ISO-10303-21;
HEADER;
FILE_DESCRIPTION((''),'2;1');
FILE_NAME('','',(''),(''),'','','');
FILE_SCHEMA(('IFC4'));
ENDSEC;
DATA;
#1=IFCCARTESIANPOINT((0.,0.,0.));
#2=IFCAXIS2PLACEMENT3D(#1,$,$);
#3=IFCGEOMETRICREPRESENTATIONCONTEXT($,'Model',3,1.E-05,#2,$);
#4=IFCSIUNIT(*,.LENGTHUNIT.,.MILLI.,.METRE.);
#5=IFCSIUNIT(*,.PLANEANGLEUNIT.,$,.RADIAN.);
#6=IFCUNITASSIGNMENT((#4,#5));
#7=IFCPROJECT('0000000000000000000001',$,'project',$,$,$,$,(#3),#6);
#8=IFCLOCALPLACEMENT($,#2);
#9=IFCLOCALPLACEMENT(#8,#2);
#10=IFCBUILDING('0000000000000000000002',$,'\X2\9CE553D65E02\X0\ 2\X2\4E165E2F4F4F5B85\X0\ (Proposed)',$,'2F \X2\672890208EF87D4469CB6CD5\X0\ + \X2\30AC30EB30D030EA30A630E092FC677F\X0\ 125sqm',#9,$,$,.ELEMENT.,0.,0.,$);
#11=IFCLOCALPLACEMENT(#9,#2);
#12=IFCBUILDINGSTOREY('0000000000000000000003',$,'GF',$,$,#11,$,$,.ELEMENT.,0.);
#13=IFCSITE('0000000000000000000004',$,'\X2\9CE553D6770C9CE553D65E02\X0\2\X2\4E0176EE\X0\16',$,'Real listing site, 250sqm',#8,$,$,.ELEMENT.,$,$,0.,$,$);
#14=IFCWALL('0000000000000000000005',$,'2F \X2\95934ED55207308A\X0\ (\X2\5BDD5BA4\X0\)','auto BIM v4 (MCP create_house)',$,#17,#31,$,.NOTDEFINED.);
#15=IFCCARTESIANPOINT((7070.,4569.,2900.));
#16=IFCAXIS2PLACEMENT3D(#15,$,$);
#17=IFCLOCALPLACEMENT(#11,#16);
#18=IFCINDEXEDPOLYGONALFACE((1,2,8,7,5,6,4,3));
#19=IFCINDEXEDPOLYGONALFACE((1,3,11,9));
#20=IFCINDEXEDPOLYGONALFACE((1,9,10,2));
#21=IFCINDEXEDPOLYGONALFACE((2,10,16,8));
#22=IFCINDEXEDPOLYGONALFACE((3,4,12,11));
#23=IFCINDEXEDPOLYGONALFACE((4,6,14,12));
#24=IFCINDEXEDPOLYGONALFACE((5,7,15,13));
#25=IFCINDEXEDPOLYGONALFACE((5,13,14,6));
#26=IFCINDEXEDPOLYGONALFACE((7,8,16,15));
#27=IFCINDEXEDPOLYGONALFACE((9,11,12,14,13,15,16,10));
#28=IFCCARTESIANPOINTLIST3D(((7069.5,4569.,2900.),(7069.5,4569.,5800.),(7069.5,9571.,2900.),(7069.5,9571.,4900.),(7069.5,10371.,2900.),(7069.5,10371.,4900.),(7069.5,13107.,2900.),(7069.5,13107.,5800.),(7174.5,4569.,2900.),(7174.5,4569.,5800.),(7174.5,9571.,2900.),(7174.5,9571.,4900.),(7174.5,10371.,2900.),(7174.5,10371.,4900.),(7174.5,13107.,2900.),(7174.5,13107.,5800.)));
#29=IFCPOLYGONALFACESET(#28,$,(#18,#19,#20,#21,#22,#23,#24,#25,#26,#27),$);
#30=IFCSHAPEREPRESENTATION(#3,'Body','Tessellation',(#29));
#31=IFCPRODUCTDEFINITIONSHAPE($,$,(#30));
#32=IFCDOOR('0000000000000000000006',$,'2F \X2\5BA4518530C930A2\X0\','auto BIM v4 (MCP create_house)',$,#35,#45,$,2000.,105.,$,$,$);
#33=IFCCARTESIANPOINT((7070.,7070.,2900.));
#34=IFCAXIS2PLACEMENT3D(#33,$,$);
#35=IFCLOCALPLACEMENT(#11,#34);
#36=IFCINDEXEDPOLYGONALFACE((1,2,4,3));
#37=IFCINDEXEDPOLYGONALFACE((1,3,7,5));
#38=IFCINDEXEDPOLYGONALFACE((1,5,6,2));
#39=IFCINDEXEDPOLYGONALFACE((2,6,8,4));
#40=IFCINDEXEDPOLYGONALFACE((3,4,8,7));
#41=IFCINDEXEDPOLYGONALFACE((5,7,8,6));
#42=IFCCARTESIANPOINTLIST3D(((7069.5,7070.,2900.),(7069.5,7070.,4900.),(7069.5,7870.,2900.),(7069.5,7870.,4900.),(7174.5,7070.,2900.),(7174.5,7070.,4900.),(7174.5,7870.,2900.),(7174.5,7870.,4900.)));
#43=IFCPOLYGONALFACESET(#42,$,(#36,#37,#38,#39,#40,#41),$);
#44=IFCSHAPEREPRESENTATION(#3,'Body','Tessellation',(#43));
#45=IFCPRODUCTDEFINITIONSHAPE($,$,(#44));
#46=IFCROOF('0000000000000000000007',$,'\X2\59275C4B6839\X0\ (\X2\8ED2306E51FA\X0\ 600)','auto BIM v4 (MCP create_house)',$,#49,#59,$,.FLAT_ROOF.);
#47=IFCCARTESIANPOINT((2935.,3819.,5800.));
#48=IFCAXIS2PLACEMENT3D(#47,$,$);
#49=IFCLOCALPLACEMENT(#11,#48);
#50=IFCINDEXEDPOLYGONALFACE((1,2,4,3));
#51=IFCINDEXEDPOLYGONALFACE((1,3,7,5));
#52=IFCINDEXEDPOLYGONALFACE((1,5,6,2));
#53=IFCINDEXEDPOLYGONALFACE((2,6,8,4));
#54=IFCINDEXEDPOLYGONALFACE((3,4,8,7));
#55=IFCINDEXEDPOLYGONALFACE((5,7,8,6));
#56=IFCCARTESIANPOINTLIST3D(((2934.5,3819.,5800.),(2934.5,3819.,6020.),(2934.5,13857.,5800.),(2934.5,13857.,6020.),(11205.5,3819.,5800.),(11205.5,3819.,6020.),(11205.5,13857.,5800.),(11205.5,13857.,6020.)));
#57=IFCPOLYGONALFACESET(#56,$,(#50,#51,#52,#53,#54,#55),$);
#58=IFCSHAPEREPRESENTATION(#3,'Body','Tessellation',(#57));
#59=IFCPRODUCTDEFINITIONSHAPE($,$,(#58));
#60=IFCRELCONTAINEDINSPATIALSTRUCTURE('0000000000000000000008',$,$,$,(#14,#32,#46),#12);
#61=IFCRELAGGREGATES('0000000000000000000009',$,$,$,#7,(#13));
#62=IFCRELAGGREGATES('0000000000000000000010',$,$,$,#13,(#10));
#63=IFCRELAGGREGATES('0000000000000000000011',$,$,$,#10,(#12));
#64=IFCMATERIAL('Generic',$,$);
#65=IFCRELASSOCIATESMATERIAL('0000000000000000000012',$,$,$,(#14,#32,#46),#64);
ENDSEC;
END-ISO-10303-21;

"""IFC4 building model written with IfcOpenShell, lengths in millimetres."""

from ifc_helpers import new_model, si_unit, frame, frame_2d, origin, place, context, project, spatial, rectangle, extrude, material, element, fill, save


model = new_model("IFC4")

# Units and contexts
model_context = context("Model", 3, precision=1e-05, world=origin())
ifc_project = project(units=[si_unit("LENGTHUNIT", "METRE", prefix="MILLI"), si_unit("PLANEANGLEUNIT", "RADIAN")], contexts=[model_context])

# Site, building, storey
site_placement = place(None, origin())
site = spatial("IfcSite", under=ifc_project, at=site_placement, Name="鳥取県鳥取市2丁目16", ObjectType="Real listing site, 250sqm", CompositionType="ELEMENT", RefElevation=0.0)
building_placement = place(site_placement, origin())
building = spatial("IfcBuilding", under=site, at=building_placement, Name="鳥取市 2世帯住宅 (Proposed)", ObjectType="2F 木造軸組構法 + ガルバリウム鋼板 125sqm", CompositionType="ELEMENT", ElevationOfRefHeight=0.0, ElevationOfTerrain=0.0)
storey_placement = place(building_placement, origin())
storey = spatial("IfcBuildingStorey", under=building, at=storey_placement, Name="GF", CompositionType="ELEMENT", Elevation=0.0)

# Shared definitions
ifc_material = material(Name="Generic")

# Wall, opening, door
wall_1_placement = place(storey_placement, frame((7070.0, 4569.0, 2900.0)))
wall_1 = element("IfcWall", 1, at=wall_1_placement, inside=storey, material=ifc_material, Name="2F 間仕切り (寝室)", Description="auto BIM v4 (MCP create_house)", PredefinedType="NOTDEFINED", context=model_context, shape_type="SweptSolid", body=[
    extrude(rectangle(XDim=105.0, YDim=8538.0, at=frame_2d((52.0, 4269.0))), frame((7070.0, 4569.0, 2900.0)), (0.0, 0.0, 1.0), 2900.0),
])
opening_1_placement = place(storey_placement, frame((7070.0, 7070.0, 2900.0)))
opening_1 = element("IfcOpeningElement", 2, at=opening_1_placement, cuts=wall_1, PredefinedType="NOTDEFINED", context=model_context, shape_type="SweptSolid", body=[
    extrude(rectangle(XDim=105.0, YDim=800.0, at=frame_2d((52.0, 400.0))), frame((7070.0, 7070.0, 2900.0)), (0.0, 0.0, 1.0), 2000.0),
])
door_1_placement = place(storey_placement, frame((7070.0, 7070.0, 2900.0)))
door_1 = element("IfcDoor", 3, at=door_1_placement, inside=storey, material=ifc_material, Name="2F 室内ドア", Description="auto BIM v4 (MCP create_house)", OverallHeight=2000.0, OverallWidth=105.0, context=model_context, shape_type="SweptSolid", body=[
    extrude(rectangle(XDim=105.0, YDim=800.0, at=frame_2d((52.0, 400.0))), frame((7070.0, 7070.0, 2900.0)), (0.0, 0.0, 1.0), 2000.0),
])
fill(opening_1, door_1)

# Roof
roof_placement = place(storey_placement, frame((2935.0, 3819.0, 5800.0)))
element("IfcRoof", 4, at=roof_placement, inside=storey, material=ifc_material, Name="大屋根 (軒の出 600)", Description="auto BIM v4 (MCP create_house)", PredefinedType="FLAT_ROOF", context=model_context, shape_type="SweptSolid", body=[
    extrude(rectangle(XDim=8271.0, YDim=10038.0, at=frame_2d((4135.0, 5019.0))), frame((2935.0, 3819.0, 5800.0)), (0.0, 0.0, 1.0), 220.0),
])

save(model, "model.ifc")
